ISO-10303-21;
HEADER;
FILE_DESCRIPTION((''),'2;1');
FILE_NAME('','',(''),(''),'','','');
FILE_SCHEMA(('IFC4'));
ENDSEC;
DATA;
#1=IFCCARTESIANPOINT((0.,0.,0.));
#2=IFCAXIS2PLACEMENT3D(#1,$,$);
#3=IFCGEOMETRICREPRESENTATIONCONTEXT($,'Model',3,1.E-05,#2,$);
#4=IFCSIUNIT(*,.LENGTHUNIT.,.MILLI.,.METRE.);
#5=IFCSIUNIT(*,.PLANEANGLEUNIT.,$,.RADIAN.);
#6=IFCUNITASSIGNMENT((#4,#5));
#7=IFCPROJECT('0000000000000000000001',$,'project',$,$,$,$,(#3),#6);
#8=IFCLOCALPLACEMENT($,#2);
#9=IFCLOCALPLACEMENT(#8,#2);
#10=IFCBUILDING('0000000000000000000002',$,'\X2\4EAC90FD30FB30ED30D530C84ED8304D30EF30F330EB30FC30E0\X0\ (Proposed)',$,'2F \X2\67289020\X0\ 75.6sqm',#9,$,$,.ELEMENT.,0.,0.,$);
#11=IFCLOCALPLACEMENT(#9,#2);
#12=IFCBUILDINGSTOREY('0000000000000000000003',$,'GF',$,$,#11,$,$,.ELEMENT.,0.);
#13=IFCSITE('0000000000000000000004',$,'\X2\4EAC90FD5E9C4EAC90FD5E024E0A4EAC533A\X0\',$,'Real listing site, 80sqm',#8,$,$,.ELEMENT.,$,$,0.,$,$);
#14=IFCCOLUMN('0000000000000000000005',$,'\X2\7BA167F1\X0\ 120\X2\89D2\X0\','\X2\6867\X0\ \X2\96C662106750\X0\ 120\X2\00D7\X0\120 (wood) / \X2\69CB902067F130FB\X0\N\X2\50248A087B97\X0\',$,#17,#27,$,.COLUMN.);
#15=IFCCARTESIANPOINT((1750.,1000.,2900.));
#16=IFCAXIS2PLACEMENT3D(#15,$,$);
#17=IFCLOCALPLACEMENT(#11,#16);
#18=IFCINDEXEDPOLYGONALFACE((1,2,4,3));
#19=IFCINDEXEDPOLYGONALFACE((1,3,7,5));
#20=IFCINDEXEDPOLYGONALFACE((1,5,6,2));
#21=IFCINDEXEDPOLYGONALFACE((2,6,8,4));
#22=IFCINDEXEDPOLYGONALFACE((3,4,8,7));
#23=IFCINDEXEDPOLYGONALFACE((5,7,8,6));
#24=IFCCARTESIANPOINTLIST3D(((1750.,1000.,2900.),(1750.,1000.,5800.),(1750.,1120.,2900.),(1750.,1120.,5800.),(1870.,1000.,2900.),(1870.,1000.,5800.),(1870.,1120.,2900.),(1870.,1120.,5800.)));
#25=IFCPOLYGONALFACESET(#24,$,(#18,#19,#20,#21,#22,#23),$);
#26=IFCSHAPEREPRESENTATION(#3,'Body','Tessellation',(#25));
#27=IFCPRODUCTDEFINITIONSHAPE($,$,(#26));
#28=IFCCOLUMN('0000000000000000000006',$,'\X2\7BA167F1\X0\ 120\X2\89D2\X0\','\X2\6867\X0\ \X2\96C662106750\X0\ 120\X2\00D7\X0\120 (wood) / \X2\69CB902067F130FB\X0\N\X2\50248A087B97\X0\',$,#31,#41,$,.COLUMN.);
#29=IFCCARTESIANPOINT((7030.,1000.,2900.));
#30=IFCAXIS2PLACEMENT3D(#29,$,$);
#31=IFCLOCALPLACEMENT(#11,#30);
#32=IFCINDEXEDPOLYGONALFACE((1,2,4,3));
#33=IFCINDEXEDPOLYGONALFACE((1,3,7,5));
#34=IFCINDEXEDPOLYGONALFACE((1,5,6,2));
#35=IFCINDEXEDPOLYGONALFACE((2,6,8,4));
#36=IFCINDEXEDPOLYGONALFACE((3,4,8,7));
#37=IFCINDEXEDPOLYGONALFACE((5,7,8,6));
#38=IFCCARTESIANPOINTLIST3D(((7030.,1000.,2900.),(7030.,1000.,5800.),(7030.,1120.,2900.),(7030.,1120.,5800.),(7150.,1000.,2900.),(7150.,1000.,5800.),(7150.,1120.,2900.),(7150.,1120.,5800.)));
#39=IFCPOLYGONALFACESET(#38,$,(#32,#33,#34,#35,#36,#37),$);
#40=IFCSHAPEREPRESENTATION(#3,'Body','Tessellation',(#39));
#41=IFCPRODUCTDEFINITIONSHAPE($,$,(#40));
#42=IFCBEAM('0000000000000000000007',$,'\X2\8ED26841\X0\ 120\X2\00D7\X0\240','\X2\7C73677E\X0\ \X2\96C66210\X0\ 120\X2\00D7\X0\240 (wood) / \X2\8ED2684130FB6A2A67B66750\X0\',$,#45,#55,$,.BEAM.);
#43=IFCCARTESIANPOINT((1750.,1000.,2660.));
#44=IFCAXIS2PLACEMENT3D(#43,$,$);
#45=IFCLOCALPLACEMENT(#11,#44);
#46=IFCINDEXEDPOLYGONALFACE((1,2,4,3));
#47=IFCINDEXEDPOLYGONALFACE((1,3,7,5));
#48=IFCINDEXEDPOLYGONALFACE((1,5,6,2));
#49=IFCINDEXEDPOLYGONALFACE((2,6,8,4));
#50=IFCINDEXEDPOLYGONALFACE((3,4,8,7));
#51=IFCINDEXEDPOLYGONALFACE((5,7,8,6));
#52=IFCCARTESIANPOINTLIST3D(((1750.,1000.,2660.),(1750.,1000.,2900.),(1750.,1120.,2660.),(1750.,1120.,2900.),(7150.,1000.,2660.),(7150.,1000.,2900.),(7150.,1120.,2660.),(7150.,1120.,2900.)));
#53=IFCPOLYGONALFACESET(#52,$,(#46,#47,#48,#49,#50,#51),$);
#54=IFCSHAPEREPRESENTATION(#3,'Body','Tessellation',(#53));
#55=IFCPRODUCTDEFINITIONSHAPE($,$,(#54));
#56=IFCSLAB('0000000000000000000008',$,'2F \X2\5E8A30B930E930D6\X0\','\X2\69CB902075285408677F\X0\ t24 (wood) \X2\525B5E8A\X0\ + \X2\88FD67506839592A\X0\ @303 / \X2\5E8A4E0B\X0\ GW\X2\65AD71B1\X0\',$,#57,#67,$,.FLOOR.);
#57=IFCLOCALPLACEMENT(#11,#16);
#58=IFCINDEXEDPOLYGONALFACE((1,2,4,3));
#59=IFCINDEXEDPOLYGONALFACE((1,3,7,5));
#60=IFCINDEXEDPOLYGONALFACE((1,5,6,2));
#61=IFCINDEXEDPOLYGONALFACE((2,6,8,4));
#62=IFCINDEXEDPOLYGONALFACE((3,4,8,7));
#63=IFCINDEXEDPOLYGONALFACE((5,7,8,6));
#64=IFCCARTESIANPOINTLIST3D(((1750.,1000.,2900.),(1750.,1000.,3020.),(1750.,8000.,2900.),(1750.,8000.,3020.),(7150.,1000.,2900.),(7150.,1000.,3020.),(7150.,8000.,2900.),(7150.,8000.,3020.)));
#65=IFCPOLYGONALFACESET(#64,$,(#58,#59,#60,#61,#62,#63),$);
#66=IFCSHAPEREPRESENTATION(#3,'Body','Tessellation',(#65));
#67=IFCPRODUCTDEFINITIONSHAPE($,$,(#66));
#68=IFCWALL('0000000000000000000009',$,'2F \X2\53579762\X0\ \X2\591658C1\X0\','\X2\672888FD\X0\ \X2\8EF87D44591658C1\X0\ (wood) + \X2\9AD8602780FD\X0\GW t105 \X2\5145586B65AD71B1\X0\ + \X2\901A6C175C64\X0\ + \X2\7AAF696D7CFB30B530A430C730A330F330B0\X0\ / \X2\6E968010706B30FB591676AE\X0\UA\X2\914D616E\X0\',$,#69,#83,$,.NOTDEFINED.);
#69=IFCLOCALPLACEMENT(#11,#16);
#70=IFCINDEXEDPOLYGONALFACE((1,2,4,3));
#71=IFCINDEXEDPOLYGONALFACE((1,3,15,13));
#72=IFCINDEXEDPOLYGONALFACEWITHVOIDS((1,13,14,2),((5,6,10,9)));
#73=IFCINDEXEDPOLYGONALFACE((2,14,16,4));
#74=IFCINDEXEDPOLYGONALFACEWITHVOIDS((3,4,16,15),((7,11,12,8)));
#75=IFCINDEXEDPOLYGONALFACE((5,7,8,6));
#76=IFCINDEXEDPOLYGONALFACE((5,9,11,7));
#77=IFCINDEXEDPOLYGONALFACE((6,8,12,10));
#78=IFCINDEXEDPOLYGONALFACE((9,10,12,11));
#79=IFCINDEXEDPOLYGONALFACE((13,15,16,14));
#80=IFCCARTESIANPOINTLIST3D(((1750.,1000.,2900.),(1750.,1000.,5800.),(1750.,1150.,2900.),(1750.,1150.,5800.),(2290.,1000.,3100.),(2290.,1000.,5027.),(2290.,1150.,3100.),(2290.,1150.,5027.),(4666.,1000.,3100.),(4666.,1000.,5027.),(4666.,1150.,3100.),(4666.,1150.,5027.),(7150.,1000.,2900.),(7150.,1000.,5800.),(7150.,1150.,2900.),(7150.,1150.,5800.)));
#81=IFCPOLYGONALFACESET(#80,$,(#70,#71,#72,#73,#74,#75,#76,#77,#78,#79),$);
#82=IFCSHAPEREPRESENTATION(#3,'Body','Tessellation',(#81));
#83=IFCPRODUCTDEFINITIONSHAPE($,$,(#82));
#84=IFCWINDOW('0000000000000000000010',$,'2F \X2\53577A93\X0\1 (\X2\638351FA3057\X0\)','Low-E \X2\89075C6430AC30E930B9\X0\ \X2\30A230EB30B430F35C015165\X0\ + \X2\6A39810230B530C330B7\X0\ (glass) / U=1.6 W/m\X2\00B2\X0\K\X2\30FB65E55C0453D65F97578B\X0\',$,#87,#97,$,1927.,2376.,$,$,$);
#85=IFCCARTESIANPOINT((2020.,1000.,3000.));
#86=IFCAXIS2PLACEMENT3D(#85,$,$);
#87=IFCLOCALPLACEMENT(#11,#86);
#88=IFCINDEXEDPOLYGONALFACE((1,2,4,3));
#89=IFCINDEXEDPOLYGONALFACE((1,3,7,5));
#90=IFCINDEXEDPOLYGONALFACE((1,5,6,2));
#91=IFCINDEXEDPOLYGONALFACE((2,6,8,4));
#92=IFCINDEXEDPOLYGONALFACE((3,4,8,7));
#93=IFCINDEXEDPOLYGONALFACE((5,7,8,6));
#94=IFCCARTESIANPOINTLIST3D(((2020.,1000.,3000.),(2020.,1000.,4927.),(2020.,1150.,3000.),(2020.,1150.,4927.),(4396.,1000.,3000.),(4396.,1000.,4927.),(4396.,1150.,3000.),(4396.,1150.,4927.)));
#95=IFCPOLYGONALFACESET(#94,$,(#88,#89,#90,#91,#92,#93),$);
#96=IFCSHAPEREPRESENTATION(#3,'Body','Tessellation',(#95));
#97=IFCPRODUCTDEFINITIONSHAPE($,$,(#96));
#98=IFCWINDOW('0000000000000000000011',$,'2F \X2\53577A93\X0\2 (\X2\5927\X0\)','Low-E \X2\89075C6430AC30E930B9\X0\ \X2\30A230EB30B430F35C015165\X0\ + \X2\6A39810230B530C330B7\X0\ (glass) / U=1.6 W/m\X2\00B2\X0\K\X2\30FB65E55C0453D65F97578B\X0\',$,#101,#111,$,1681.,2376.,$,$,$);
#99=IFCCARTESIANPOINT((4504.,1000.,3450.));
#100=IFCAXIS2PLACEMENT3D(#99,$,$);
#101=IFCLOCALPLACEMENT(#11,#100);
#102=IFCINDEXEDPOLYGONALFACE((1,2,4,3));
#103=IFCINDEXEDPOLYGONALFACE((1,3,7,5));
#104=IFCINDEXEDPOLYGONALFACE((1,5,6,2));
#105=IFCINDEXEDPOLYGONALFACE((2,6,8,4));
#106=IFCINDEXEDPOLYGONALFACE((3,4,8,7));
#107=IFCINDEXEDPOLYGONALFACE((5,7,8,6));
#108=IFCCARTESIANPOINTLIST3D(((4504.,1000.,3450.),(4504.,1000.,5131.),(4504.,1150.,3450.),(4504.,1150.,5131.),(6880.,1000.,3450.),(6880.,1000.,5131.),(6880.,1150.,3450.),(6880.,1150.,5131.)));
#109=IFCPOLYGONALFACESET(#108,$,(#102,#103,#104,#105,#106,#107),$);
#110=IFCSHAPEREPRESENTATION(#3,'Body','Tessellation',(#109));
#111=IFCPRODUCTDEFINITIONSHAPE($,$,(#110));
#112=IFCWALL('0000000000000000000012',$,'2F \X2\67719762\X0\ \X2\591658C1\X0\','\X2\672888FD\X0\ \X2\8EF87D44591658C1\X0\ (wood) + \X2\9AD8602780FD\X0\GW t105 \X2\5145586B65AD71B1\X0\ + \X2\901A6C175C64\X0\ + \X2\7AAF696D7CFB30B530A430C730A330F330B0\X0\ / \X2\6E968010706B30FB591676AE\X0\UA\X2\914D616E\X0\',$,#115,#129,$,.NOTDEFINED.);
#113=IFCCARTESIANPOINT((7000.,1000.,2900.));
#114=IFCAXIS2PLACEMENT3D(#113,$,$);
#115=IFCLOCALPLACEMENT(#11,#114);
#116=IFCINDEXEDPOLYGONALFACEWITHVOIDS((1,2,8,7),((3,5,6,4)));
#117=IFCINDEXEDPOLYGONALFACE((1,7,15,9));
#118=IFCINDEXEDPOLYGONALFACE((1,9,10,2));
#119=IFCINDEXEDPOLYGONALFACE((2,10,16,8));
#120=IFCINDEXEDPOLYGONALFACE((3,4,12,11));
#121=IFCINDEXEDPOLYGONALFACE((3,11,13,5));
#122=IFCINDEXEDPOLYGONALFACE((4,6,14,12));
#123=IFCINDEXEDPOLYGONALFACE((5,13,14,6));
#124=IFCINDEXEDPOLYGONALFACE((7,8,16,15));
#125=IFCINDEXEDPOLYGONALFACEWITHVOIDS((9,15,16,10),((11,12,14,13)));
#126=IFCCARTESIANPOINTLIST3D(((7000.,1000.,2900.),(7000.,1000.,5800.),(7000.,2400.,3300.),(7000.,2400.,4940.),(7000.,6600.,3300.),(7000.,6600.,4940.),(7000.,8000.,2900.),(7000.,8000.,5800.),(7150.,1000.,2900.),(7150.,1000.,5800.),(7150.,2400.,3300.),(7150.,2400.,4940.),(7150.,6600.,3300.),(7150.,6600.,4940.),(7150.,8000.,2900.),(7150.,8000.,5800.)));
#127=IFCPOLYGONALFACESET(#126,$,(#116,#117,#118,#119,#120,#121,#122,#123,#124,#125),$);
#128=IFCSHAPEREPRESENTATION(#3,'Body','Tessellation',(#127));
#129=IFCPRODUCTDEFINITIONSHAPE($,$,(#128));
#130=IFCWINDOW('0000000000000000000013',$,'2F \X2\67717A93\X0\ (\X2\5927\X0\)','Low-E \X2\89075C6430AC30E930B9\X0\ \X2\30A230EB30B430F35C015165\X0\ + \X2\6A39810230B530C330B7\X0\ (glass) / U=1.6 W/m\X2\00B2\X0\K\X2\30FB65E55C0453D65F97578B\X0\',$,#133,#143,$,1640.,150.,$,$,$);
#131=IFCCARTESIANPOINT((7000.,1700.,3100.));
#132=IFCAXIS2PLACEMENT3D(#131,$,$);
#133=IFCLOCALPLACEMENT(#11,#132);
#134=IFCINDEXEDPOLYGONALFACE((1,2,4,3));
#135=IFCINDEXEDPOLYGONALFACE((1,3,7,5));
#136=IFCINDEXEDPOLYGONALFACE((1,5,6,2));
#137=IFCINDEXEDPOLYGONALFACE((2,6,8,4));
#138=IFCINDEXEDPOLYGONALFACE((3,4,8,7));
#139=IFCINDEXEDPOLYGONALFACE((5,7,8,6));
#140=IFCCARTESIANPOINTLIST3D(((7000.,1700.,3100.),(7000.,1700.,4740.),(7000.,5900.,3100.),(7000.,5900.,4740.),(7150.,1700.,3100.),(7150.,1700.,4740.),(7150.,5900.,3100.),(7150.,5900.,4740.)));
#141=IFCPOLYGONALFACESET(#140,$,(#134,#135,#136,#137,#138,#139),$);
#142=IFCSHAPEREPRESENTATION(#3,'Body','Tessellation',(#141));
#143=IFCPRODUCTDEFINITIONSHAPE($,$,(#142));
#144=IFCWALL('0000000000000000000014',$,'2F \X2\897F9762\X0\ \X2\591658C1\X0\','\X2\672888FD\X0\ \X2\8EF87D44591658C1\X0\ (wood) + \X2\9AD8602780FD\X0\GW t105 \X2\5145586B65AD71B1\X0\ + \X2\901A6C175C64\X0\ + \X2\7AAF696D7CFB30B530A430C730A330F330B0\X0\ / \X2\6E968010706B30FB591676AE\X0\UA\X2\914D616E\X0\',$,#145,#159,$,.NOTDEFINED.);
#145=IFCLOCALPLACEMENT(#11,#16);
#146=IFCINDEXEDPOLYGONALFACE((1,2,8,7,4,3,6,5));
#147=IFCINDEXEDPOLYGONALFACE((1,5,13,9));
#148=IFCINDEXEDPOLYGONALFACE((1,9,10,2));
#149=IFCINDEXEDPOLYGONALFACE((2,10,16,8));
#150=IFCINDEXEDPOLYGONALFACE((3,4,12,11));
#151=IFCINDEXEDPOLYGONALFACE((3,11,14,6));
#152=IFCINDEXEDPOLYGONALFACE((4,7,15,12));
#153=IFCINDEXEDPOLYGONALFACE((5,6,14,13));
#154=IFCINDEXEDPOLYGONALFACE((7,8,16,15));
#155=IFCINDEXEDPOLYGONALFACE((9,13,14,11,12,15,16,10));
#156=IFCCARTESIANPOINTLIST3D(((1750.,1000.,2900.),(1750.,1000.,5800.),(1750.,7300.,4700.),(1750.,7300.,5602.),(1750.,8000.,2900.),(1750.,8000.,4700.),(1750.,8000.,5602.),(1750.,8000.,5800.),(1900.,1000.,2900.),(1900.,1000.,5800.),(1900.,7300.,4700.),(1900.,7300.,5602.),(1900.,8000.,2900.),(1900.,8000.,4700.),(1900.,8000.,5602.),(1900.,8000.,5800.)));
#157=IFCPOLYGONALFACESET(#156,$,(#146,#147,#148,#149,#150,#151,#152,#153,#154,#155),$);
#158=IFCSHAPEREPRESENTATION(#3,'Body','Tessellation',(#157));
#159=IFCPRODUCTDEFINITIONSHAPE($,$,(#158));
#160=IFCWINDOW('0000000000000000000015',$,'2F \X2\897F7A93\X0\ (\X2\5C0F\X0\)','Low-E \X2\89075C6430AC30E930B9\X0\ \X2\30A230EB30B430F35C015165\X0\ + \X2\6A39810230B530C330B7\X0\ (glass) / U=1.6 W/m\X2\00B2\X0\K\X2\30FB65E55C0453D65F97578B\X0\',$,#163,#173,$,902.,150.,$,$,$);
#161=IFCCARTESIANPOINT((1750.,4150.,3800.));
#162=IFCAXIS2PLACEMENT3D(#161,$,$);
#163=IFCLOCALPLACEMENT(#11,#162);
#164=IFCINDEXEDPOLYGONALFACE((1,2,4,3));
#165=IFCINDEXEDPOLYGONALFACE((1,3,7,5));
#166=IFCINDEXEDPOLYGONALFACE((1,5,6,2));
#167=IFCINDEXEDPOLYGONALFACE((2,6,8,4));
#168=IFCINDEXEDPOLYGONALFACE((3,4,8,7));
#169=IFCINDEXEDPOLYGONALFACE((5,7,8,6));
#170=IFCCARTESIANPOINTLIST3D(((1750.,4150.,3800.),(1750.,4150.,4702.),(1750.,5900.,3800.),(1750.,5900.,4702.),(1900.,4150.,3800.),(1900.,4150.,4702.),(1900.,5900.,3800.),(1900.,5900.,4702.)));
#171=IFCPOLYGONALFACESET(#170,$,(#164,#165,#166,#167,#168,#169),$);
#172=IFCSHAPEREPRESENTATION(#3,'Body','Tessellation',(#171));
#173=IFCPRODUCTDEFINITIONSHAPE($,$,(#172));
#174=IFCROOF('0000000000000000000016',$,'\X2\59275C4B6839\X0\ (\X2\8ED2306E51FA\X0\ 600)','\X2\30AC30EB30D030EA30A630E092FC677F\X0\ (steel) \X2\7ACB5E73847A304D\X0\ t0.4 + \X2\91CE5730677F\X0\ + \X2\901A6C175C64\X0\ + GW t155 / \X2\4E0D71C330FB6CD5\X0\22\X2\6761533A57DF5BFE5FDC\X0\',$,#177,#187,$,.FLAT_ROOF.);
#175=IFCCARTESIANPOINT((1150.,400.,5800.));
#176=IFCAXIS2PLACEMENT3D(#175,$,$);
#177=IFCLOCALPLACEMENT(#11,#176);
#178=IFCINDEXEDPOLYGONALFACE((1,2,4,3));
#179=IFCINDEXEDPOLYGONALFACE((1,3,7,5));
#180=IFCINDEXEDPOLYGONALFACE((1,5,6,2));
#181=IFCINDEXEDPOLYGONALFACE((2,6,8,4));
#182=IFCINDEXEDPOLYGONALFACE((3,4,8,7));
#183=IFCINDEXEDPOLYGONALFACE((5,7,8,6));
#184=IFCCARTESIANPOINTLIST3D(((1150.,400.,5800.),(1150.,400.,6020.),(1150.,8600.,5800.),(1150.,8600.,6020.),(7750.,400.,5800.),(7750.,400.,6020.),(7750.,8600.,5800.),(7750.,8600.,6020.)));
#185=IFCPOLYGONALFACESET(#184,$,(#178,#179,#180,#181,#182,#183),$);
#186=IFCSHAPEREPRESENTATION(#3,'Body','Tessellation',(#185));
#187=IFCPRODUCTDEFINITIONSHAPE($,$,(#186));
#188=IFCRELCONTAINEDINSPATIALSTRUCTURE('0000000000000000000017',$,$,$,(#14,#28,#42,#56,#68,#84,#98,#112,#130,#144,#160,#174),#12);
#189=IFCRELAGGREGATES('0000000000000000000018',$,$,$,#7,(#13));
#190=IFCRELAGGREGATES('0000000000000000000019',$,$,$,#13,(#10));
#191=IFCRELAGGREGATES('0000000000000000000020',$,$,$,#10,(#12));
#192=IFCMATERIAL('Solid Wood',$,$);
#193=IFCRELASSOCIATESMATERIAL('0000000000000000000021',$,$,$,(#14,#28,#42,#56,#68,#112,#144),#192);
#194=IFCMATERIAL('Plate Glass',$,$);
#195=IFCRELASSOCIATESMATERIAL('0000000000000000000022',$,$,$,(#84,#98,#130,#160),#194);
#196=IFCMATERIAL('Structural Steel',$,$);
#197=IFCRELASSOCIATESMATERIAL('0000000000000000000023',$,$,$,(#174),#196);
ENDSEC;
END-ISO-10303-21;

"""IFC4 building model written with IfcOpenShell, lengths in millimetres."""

from ifc_helpers import new_model, si_unit, frame, frame_2d, origin, place, context, project, spatial, rectangle, extrude, material, element, fill, save


model = new_model("IFC4")

# Units and contexts
model_context = context("Model", 3, precision=1e-05, world=origin())
ifc_project = project(units=[si_unit("LENGTHUNIT", "METRE", prefix="MILLI"), si_unit("PLANEANGLEUNIT", "RADIAN")], contexts=[model_context])

# Site, building, storey
site_placement = place(None, origin())
site = spatial("IfcSite", under=ifc_project, at=site_placement, Name="京都府京都市上京区", ObjectType="Real listing site, 80sqm", CompositionType="ELEMENT", RefElevation=0.0)
building_placement = place(site_placement, origin())
building = spatial("IfcBuilding", under=site, at=building_placement, Name="京都・ロフト付きワンルーム (Proposed)", ObjectType="2F 木造 75.6sqm", CompositionType="ELEMENT", ElevationOfRefHeight=0.0, ElevationOfTerrain=0.0)
storey_placement = place(building_placement, origin())
storey = spatial("IfcBuildingStorey", under=building, at=storey_placement, Name="GF", CompositionType="ELEMENT", Elevation=0.0)

# Columns
ifc_material_1 = material(Name="Solid Wood")
column_1_placement = place(storey_placement, frame((1750.0, 1000.0, 2900.0)))
element("IfcColumn", 1, at=column_1_placement, inside=storey, material=ifc_material_1, Name="管柱 120角", Description="桧 集成材 120×120 (wood) / 構造柱・N値計算", PredefinedType="COLUMN", context=model_context, shape_type="SweptSolid", body=[
    extrude(rectangle(XDim=120.0, YDim=120.0, at=frame_2d((60.0, 60.0))), frame((1750.0, 1000.0, 2900.0)), (0.0, 0.0, 1.0), 2900.0),
])
column_2_placement = place(storey_placement, frame((7030.0, 1000.0, 2900.0)))
element("IfcColumn", 2, at=column_2_placement, inside=storey, material=ifc_material_1, Name="管柱 120角", Description="桧 集成材 120×120 (wood) / 構造柱・N値計算", PredefinedType="COLUMN", context=model_context, shape_type="SweptSolid", body=[
    extrude(rectangle(XDim=120.0, YDim=120.0, at=frame_2d((60.0, 60.0))), frame((7030.0, 1000.0, 2900.0)), (0.0, 0.0, 1.0), 2900.0),
])

# Beam
beam_1_placement = place(storey_placement, frame((1750.0, 1000.0, 2660.0)))
element("IfcBeam", 3, at=beam_1_placement, inside=storey, material=ifc_material_1, Name="軒桁 120×240", Description="米松 集成 120×240 (wood) / 軒桁・横架材", PredefinedType="BEAM", context=model_context, shape_type="SweptSolid", body=[
    extrude(rectangle(XDim=5400.0, YDim=120.0, at=frame_2d((2700.0, 60.0))), frame((1750.0, 1000.0, 2660.0)), (0.0, 0.0, 1.0), 240.0),
])

# Slab
slab_placement = place(storey_placement, frame((1750.0, 1000.0, 2900.0)))
element("IfcSlab", 4, at=slab_placement, inside=storey, material=ifc_material_1, Name="2F 床スラブ", Description="構造用合板 t24 (wood) 剛床 + 製材根太 @303 / 床下 GW断熱", PredefinedType="FLOOR", context=model_context, shape_type="SweptSolid", body=[
    extrude(rectangle(XDim=5400.0, YDim=7000.0, at=frame_2d((2700.0, 3500.0))), frame((1750.0, 1000.0, 2900.0)), (0.0, 0.0, 1.0), 120.0),
])

# Wall, openings, windows
wall_1_placement = place(storey_placement, frame((1750.0, 1000.0, 2900.0)))
wall_1 = element("IfcWall", 5, at=wall_1_placement, inside=storey, material=ifc_material_1, Name="2F 南面 外壁", Description="木製 軸組外壁 (wood) + 高性能GW t105 充填断熱 + 通気層 + 窯業系サイディング / 準耐火・外皮UA配慮", PredefinedType="NOTDEFINED", context=model_context, shape_type="SweptSolid", body=[
    extrude(rectangle(XDim=5400.0, YDim=150.0, at=frame_2d((2700.0, 75.0))), frame((1750.0, 1000.0, 2900.0)), (0.0, 0.0, 1.0), 2900.0),
])
opening_1_placement = place(storey_placement, frame((2020.0, 1000.0, 3000.0)))
opening_1 = element("IfcOpeningElement", 6, at=opening_1_placement, cuts=wall_1, PredefinedType="NOTDEFINED", context=model_context, shape_type="SweptSolid", body=[
    extrude(rectangle(XDim=2376.0, YDim=150.0, at=frame_2d((1188.0, 75.0))), frame((2020.0, 1000.0, 3000.0)), (0.0, 0.0, 1.0), 1927.0),
])
opening_2_placement = place(storey_placement, frame((4504.0, 1000.0, 3450.0)))
opening_2 = element("IfcOpeningElement", 7, at=opening_2_placement, cuts=wall_1, PredefinedType="NOTDEFINED", context=model_context, shape_type="SweptSolid", body=[
    extrude(rectangle(XDim=2376.0, YDim=150.0, at=frame_2d((1188.0, 75.0))), frame((4504.0, 1000.0, 3450.0)), (0.0, 0.0, 1.0), 1681.0),
])
ifc_material_2 = material(Name="Plate Glass")
window_1_placement = place(storey_placement, frame((2020.0, 1000.0, 3000.0)))
window_1 = element("IfcWindow", 8, at=window_1_placement, inside=storey, material=ifc_material_2, Name="2F 南窓1 (掃出し)", Description="Low-E 複層ガラス アルゴン封入 + 樹脂サッシ (glass) / U=1.6 W/m²K・日射取得型", OverallHeight=1927.0, OverallWidth=2376.0, context=model_context, shape_type="SweptSolid", body=[
    extrude(rectangle(XDim=2376.0, YDim=150.0, at=frame_2d((1188.0, 75.0))), frame((2020.0, 1000.0, 3000.0)), (0.0, 0.0, 1.0), 1927.0),
])
fill(opening_1, window_1)
window_2_placement = place(storey_placement, frame((4504.0, 1000.0, 3450.0)))
window_2 = element("IfcWindow", 9, at=window_2_placement, inside=storey, material=ifc_material_2, Name="2F 南窓2 (大)", Description="Low-E 複層ガラス アルゴン封入 + 樹脂サッシ (glass) / U=1.6 W/m²K・日射取得型", OverallHeight=1681.0, OverallWidth=2376.0, context=model_context, shape_type="SweptSolid", body=[
    extrude(rectangle(XDim=2376.0, YDim=150.0, at=frame_2d((1188.0, 75.0))), frame((4504.0, 1000.0, 3450.0)), (0.0, 0.0, 1.0), 1681.0),
])
fill(opening_2, window_2)

# Walls, openings, windows
wall_2_placement = place(storey_placement, frame((7000.0, 1000.0, 2900.0)))
wall_2 = element("IfcWall", 10, at=wall_2_placement, inside=storey, material=ifc_material_1, Name="2F 東面 外壁", Description="木製 軸組外壁 (wood) + 高性能GW t105 充填断熱 + 通気層 + 窯業系サイディング / 準耐火・外皮UA配慮", PredefinedType="NOTDEFINED", context=model_context, shape_type="SweptSolid", body=[
    extrude(rectangle(XDim=150.0, YDim=7000.0, at=frame_2d((75.0, 3500.0))), frame((7000.0, 1000.0, 2900.0)), (0.0, 0.0, 1.0), 2900.0),
])
opening_3_placement = place(storey_placement, frame((7000.0, 1700.0, 3100.0)))
opening_3 = element("IfcOpeningElement", 11, at=opening_3_placement, cuts=wall_2, PredefinedType="NOTDEFINED", context=model_context, shape_type="SweptSolid", body=[
    extrude(rectangle(XDim=150.0, YDim=4200.0, at=frame_2d((75.0, 2100.0))), frame((7000.0, 1700.0, 3100.0)), (0.0, 0.0, 1.0), 1640.0),
])
window_3_placement = place(storey_placement, frame((7000.0, 1700.0, 3100.0)))
window_3 = element("IfcWindow", 12, at=window_3_placement, inside=storey, material=ifc_material_2, Name="2F 東窓 (大)", Description="Low-E 複層ガラス アルゴン封入 + 樹脂サッシ (glass) / U=1.6 W/m²K・日射取得型", OverallHeight=1640.0, OverallWidth=150.0, context=model_context, shape_type="SweptSolid", body=[
    extrude(rectangle(XDim=150.0, YDim=4200.0, at=frame_2d((75.0, 2100.0))), frame((7000.0, 1700.0, 3100.0)), (0.0, 0.0, 1.0), 1640.0),
])
fill(opening_3, window_3)
wall_3_placement = place(storey_placement, frame((1750.0, 1000.0, 2900.0)))
wall_3 = element("IfcWall", 13, at=wall_3_placement, inside=storey, material=ifc_material_1, Name="2F 西面 外壁", Description="木製 軸組外壁 (wood) + 高性能GW t105 充填断熱 + 通気層 + 窯業系サイディング / 準耐火・外皮UA配慮", PredefinedType="NOTDEFINED", context=model_context, shape_type="SweptSolid", body=[
    extrude(rectangle(XDim=150.0, YDim=7000.0, at=frame_2d((75.0, 3500.0))), frame((1750.0, 1000.0, 2900.0)), (0.0, 0.0, 1.0), 2900.0),
])
opening_4_placement = place(storey_placement, frame((1750.0, 4150.0, 3800.0)))
opening_4 = element("IfcOpeningElement", 14, at=opening_4_placement, cuts=wall_3, PredefinedType="NOTDEFINED", context=model_context, shape_type="SweptSolid", body=[
    extrude(rectangle(XDim=150.0, YDim=1750.0, at=frame_2d((75.0, 875.0))), frame((1750.0, 4150.0, 3800.0)), (0.0, 0.0, 1.0), 902.0),
])
window_4_placement = place(storey_placement, frame((1750.0, 4150.0, 3800.0)))
window_4 = element("IfcWindow", 15, at=window_4_placement, inside=storey, material=ifc_material_2, Name="2F 西窓 (小)", Description="Low-E 複層ガラス アルゴン封入 + 樹脂サッシ (glass) / U=1.6 W/m²K・日射取得型", OverallHeight=902.0, OverallWidth=150.0, context=model_context, shape_type="SweptSolid", body=[
    extrude(rectangle(XDim=150.0, YDim=1750.0, at=frame_2d((75.0, 875.0))), frame((1750.0, 4150.0, 3800.0)), (0.0, 0.0, 1.0), 902.0),
])
fill(opening_4, window_4)

# Roof
ifc_material_3 = material(Name="Structural Steel")
roof_placement = place(storey_placement, frame((1150.0, 400.0, 5800.0)))
element("IfcRoof", 16, at=roof_placement, inside=storey, material=ifc_material_3, Name="大屋根 (軒の出 600)", Description="ガルバリウム鋼板 (steel) 立平葺き t0.4 + 野地板 + 通気層 + GW t155 / 不燃・法22条区域対応", PredefinedType="FLAT_ROOF", context=model_context, shape_type="SweptSolid", body=[
    extrude(rectangle(XDim=6600.0, YDim=8200.0, at=frame_2d((3300.0, 4100.0))), frame((1150.0, 400.0, 5800.0)), (0.0, 0.0, 1.0), 220.0),
])

save(model, "model.ifc")
